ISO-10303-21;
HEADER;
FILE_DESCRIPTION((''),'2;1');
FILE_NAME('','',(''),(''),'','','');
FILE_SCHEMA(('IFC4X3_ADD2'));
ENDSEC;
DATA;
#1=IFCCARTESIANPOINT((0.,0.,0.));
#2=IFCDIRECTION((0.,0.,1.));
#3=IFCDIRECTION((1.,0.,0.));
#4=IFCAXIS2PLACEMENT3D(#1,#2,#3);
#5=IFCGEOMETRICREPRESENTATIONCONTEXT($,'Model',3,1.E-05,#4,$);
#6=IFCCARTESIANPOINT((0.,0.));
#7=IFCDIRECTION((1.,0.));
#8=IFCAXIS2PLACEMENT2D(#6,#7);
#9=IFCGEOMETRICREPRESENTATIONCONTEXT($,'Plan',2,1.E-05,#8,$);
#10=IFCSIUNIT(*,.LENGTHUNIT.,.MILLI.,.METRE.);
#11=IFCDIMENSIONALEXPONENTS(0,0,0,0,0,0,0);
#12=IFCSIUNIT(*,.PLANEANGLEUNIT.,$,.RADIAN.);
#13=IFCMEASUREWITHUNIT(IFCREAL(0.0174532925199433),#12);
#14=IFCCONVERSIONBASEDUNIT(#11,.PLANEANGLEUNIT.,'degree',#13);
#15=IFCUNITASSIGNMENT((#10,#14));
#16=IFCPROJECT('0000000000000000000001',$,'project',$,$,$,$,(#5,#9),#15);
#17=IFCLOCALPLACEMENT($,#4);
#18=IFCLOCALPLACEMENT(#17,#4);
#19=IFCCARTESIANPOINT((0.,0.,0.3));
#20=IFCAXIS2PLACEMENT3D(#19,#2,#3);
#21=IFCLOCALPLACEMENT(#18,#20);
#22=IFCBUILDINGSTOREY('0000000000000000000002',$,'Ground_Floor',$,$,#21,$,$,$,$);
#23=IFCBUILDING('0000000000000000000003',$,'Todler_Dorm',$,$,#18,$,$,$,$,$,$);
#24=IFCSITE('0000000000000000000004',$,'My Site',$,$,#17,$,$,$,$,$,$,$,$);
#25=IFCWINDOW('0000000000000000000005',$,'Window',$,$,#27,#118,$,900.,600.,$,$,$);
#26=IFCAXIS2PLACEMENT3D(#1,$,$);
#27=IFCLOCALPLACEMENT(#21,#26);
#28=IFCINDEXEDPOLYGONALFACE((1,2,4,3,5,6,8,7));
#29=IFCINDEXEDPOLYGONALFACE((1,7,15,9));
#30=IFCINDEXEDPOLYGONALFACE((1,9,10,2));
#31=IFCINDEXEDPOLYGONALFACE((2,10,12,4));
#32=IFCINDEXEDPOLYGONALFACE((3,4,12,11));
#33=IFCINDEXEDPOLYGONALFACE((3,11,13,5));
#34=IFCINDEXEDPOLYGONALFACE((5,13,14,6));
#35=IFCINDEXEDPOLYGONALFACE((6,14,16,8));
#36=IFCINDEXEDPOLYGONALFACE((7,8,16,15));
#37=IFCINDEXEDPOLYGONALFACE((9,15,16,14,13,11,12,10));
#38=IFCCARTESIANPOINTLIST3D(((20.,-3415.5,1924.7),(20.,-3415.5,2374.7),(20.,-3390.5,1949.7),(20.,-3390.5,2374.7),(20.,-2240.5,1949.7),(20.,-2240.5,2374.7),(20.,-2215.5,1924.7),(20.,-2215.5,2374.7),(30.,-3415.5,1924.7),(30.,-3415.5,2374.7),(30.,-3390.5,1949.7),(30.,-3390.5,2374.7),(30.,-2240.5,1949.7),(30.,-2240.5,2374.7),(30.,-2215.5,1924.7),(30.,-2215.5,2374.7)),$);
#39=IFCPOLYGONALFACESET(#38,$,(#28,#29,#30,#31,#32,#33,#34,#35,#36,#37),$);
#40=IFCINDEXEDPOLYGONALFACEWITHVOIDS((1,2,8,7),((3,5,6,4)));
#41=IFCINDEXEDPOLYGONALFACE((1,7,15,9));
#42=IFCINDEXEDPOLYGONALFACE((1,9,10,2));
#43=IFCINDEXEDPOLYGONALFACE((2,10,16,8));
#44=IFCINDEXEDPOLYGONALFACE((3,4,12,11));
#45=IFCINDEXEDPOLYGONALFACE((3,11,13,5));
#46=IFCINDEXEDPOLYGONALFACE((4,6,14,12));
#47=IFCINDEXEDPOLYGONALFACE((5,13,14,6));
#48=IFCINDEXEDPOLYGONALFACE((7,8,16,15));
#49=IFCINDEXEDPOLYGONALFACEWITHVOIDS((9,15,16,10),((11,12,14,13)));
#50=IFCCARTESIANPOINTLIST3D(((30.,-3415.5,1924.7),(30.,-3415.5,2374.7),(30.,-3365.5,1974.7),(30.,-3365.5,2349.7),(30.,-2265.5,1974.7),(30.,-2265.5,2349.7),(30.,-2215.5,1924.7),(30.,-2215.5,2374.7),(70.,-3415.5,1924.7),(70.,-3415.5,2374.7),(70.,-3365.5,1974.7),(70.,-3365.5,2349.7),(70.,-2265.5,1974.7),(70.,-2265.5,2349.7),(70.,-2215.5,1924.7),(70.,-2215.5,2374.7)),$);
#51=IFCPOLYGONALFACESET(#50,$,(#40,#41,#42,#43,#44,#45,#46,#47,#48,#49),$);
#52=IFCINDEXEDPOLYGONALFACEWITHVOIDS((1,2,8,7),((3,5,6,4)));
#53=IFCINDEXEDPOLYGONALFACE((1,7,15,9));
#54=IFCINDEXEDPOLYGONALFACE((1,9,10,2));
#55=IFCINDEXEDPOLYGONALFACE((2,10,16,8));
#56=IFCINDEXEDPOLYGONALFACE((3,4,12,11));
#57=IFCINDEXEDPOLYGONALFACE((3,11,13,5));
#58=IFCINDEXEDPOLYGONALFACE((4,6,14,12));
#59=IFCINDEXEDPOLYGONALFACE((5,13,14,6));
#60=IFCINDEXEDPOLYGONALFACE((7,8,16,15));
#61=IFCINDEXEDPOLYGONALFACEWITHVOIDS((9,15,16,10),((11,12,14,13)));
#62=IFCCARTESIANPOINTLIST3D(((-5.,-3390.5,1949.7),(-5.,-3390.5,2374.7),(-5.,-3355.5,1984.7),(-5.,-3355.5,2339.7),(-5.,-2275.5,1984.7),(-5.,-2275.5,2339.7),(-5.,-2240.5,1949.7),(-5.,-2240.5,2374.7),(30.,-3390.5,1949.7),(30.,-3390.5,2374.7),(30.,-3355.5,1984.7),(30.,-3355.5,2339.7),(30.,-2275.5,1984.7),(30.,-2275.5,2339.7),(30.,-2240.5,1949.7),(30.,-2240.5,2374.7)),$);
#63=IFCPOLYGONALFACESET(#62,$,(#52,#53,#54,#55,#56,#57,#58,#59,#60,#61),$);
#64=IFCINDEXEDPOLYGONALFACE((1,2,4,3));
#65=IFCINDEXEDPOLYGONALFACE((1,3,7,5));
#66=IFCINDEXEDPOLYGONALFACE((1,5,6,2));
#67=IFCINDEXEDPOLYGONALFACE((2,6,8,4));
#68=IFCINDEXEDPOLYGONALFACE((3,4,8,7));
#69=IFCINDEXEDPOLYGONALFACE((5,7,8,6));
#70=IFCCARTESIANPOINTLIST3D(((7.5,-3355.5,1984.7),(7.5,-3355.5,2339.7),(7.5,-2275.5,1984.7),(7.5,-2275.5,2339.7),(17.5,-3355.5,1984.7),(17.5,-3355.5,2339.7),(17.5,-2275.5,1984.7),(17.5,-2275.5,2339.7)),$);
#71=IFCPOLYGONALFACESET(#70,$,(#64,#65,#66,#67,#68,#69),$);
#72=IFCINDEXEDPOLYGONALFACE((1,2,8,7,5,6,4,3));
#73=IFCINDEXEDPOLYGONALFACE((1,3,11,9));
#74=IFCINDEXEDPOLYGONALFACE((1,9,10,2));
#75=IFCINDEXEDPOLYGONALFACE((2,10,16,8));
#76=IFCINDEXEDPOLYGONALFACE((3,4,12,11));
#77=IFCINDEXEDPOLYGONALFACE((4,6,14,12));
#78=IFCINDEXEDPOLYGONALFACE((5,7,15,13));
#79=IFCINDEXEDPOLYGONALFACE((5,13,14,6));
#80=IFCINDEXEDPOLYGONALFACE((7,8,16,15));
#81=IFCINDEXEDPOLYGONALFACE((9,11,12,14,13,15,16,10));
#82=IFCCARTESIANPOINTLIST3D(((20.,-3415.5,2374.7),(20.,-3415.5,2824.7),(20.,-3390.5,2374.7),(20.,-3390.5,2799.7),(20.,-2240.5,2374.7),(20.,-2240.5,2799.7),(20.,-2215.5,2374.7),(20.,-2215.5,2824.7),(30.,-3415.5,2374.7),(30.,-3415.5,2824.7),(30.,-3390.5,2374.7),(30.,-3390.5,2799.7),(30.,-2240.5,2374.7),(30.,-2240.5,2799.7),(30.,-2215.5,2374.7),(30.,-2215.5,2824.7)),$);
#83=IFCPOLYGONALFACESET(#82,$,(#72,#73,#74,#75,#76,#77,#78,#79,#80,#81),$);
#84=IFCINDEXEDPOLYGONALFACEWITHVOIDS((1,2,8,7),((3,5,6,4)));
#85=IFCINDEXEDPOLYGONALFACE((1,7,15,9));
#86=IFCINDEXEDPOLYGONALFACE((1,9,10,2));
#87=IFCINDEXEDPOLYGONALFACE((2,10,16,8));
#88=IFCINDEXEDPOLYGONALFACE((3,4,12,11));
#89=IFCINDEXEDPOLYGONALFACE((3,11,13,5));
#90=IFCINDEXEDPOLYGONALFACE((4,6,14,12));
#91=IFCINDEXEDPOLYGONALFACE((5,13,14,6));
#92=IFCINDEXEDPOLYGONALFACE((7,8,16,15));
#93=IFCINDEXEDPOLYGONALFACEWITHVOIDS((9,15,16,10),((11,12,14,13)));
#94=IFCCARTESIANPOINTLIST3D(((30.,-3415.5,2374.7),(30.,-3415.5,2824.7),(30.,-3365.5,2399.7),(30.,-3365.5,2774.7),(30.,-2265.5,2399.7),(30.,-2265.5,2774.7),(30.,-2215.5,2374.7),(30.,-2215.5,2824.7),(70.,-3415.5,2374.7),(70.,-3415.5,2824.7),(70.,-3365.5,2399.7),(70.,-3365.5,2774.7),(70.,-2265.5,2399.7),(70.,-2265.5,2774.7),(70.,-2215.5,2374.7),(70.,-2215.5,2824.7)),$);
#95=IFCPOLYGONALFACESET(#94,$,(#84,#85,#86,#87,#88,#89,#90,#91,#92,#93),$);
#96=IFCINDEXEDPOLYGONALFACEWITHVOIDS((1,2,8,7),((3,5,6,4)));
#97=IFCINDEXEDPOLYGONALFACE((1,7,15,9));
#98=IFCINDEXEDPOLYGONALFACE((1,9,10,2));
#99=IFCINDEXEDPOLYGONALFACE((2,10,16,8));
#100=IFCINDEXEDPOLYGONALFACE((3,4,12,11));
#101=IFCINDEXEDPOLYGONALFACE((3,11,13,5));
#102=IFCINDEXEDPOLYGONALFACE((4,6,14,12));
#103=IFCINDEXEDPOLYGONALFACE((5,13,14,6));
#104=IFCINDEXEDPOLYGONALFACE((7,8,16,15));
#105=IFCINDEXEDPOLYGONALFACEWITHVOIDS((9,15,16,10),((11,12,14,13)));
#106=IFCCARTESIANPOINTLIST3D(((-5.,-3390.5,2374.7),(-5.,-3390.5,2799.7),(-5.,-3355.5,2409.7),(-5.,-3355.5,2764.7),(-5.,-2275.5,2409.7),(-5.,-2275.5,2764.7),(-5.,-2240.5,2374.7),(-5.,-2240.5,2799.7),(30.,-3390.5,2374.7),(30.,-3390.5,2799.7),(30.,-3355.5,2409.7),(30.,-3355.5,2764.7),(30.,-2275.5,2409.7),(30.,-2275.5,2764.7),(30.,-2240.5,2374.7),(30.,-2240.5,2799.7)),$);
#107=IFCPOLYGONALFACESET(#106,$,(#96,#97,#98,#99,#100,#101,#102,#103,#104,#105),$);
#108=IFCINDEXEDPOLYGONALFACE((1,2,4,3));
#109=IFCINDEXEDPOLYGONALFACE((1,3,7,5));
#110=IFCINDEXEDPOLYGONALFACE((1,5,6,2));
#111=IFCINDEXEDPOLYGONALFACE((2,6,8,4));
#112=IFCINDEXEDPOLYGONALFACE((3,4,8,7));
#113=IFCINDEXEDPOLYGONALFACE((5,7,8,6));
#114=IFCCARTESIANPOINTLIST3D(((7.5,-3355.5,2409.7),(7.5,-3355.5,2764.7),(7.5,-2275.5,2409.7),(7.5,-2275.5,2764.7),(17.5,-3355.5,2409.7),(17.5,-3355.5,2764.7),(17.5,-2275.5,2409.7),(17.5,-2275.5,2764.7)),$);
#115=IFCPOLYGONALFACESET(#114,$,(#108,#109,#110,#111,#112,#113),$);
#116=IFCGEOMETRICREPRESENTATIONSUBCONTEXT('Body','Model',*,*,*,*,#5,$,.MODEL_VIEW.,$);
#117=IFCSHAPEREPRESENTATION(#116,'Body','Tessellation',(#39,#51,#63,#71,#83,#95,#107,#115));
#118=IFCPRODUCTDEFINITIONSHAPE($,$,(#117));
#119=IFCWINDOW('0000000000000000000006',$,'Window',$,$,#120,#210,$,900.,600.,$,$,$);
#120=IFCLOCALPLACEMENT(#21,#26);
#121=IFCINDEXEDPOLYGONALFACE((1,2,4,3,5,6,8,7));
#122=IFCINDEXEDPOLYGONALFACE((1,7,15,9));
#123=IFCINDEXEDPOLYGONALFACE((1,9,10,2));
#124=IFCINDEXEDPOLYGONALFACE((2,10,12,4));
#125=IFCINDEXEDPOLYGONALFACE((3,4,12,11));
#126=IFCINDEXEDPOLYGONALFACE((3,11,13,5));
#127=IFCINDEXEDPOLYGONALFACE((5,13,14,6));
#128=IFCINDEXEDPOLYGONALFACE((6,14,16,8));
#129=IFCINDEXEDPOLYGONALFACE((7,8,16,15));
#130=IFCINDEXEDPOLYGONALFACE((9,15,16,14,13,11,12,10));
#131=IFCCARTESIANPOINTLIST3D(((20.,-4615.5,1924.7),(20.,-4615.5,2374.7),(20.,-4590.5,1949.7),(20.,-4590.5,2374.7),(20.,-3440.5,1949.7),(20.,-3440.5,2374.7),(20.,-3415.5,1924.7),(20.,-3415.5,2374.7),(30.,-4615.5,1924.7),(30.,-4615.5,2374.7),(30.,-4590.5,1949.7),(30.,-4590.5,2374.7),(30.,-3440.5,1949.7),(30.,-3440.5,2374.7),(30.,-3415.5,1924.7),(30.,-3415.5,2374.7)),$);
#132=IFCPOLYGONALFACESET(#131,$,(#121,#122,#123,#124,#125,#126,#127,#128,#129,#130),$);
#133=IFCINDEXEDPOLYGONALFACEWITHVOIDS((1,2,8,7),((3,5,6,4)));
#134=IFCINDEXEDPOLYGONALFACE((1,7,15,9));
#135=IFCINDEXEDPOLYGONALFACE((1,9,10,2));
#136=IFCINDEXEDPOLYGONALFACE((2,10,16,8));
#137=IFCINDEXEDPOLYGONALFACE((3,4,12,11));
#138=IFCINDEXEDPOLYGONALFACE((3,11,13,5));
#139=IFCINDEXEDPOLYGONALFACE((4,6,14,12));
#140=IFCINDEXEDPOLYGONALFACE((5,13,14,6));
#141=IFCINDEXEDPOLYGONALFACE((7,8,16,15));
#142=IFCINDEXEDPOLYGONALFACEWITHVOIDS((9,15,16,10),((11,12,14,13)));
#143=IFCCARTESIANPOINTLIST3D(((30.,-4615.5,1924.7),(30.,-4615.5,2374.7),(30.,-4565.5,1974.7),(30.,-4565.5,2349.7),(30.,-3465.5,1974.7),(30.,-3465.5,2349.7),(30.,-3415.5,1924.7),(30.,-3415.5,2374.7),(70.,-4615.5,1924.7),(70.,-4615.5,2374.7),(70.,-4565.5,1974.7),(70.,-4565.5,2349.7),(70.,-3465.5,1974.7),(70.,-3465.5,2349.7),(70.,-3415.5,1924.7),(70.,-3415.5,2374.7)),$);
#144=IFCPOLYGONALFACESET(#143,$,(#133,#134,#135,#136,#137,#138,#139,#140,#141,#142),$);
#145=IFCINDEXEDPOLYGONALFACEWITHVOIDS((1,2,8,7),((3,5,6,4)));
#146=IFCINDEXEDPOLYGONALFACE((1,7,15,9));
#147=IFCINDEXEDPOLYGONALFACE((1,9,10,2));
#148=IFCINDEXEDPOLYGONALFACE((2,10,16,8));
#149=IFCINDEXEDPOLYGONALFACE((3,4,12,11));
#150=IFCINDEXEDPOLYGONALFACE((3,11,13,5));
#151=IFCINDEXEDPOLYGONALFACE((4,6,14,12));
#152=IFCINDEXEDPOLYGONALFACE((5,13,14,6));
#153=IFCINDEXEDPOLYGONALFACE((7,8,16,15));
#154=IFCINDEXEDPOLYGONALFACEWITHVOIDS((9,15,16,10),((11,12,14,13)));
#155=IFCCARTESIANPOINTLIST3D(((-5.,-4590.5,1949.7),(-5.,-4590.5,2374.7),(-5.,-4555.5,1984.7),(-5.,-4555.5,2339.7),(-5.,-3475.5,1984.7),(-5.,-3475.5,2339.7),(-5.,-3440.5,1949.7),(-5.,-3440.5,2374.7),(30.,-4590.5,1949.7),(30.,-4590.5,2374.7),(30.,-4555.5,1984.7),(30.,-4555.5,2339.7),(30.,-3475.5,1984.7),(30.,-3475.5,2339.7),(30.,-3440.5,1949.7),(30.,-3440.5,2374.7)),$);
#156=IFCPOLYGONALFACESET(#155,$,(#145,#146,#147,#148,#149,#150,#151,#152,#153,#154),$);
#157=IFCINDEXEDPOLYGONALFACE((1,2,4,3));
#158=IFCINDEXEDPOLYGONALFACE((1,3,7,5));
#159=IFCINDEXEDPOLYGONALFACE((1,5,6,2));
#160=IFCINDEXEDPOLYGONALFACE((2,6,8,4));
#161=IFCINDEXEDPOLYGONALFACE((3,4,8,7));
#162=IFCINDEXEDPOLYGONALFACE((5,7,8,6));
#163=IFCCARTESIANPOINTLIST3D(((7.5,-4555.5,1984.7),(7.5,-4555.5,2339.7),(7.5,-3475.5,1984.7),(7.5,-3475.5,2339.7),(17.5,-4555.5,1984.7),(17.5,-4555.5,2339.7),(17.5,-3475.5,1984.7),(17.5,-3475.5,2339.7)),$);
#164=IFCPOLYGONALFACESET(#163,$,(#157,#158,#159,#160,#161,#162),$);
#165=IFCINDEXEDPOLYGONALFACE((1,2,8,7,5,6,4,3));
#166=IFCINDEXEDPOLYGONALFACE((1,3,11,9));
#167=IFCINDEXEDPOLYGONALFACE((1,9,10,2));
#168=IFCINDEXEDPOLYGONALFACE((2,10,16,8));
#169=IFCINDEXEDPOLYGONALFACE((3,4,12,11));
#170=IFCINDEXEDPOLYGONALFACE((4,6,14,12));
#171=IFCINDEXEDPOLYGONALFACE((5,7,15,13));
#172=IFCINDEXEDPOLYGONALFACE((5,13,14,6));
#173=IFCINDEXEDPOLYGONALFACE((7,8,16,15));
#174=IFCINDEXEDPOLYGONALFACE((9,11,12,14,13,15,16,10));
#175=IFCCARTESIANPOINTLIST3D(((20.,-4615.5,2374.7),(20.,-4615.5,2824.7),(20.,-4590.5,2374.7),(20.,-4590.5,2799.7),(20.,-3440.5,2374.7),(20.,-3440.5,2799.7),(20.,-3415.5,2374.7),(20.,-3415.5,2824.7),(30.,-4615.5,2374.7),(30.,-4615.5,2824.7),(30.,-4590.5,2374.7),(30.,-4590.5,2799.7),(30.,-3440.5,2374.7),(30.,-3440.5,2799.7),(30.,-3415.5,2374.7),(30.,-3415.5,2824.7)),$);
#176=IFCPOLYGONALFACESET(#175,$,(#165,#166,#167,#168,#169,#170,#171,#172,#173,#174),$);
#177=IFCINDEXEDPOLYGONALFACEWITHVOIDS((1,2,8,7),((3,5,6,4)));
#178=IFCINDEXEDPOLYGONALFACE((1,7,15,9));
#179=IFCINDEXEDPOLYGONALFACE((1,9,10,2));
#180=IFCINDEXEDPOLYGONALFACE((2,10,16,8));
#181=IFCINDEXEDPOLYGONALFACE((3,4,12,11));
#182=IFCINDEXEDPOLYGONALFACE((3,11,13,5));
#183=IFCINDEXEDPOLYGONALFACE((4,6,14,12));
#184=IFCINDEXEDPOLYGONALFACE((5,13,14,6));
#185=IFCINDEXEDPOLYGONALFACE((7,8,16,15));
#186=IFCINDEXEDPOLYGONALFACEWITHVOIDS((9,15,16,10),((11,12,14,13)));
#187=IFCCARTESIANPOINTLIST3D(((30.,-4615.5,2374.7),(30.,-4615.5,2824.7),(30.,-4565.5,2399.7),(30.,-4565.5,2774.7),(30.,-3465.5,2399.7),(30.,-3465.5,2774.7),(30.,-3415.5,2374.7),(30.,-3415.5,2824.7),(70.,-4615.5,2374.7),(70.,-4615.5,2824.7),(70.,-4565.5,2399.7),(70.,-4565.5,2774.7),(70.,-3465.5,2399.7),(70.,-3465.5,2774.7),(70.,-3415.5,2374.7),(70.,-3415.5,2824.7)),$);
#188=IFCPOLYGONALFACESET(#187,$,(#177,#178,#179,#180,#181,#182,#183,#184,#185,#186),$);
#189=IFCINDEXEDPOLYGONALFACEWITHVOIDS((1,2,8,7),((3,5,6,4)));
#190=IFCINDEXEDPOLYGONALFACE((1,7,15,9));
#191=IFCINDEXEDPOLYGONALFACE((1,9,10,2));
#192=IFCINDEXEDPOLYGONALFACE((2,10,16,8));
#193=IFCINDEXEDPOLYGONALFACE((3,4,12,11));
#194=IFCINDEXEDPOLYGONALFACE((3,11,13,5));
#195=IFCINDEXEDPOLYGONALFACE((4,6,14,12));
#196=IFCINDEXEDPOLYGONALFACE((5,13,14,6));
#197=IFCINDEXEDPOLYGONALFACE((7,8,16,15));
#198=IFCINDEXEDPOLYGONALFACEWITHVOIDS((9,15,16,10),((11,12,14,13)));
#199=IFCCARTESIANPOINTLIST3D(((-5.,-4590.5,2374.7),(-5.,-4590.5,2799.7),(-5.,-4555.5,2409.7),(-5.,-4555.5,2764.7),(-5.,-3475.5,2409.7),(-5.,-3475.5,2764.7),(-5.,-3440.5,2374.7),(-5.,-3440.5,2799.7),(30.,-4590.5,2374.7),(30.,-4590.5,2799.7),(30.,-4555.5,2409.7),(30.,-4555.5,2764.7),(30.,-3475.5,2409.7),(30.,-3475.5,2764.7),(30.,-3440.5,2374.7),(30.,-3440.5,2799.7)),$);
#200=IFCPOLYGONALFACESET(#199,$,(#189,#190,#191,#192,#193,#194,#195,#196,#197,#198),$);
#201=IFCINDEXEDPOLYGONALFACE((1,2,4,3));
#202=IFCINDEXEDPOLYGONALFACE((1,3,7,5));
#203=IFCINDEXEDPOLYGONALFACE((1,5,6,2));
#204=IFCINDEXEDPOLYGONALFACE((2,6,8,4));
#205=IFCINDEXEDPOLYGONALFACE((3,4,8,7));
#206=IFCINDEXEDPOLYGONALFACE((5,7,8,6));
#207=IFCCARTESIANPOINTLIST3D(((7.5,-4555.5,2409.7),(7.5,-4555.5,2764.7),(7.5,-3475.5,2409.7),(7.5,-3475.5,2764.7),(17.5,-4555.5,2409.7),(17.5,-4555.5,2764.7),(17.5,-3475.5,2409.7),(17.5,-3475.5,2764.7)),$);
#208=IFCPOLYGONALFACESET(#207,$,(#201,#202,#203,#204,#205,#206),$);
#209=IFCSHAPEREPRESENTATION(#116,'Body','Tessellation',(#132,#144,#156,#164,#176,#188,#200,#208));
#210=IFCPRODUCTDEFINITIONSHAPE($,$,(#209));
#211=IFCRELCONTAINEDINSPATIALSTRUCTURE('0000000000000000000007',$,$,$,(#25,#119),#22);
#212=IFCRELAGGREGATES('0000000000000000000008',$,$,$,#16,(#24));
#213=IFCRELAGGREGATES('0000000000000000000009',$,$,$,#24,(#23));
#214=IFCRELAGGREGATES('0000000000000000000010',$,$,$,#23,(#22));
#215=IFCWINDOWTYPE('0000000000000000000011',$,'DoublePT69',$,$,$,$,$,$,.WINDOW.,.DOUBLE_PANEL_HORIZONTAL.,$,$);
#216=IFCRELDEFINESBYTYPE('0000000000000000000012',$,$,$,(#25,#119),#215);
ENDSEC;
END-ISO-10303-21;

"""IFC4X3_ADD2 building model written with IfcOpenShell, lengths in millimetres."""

from ifc_helpers import new_model, entity, si_unit, converted_unit, frame, origin_with_axes, origin_2d_with_axis, place, context, subcontext, project, spatial, line, indexed_curve, outline, extrude, shape, source, transform, mapped, type_object, type_shapes, element, save


model = new_model("IFC4X3_ADD2")

# Units and contexts
model_context = context("Model", 3, precision=1e-05, world=origin_with_axes())
plan_context = context("Plan", 2, precision=1e-05, world=origin_2d_with_axis())
body_context_1 = subcontext(model_context, "Body", "Model", "MODEL_VIEW")
body_context_2 = subcontext(plan_context, "Body", "Plan", "PLAN_VIEW")
ifc_project = project(units=[si_unit("LENGTHUNIT", "METRE", prefix="MILLI"), converted_unit("PLANEANGLEUNIT", "degree", entity("IfcReal", 0.0174532925199433), si_unit("PLANEANGLEUNIT", "RADIAN"), dimensions=[0, 0, 0, 0, 0, 0, 0])], contexts=[model_context, plan_context])

# Site, building, storey
site_placement = place(None, origin_with_axes())
site = spatial("IfcSite", under=ifc_project, at=site_placement, Name="My Site")
building_placement = place(site_placement, origin_with_axes())
building = spatial("IfcBuilding", under=site, at=building_placement, Name="Todler_Dorm")
storey_placement = place(building_placement, frame((0.0, 0.0, 0.3), z_axis=(0.0, 0.0, 1.0), x_axis=(1.0, 0.0, 0.0)))
storey = spatial("IfcBuildingStorey", under=building, at=storey_placement, Name="Ground_Floor")

# Windows
window_type_1 = type_object("IfcWindowType", Name="DoublePT69", PartitioningType="DOUBLE_PANEL_HORIZONTAL", PredefinedType="WINDOW")
shared_shape_1 = source(origin_with_axes(), body_context_1, "Body", "SweptSolid", [
    extrude(outline(indexed_curve([(1200.0, 450.0), (1200.0, 0.0), (0.0, 0.0), (0.0, 450.0), (25.0, 450.0), (25.0, 25.0), (1175.0, 25.0), (1175.0, 450.0)], segments=[line(1, 2, 3, 4, 5, 6, 7, 8, 1)])), frame((0.0, 90.0, 0.0), z_axis=(0.0, -1.0, 0.0), x_axis=(1.0, 0.0, 0.0)), (0.0, 0.0, -1.0), 10.0),
    extrude(outline(indexed_curve([(0.0, 0.0), (1200.0, 0.0), (1200.0, 450.0), (0.0, 450.0)], segments=[line(1, 2, 3, 4, 1)]), holes=[indexed_curve([(50.0, 50.0), (1150.0, 50.0), (1150.0, 425.0), (50.0, 425.0)], segments=[line(1, 2, 3, 4, 1)])]), frame((0.0, 50.0, 0.0), z_axis=(0.0, -1.0, 0.0), x_axis=(1.0, 0.0, 0.0)), (0.0, 0.0, -1.0), 40.0),
    extrude(outline(indexed_curve([(0.0, 0.0), (1150.0, 0.0), (1150.0, 425.0), (0.0, 425.0)], segments=[line(1, 2, 3, 4, 1)]), holes=[indexed_curve([(35.0, 35.0), (1115.0, 35.0), (1115.0, 390.0), (35.0, 390.0)], segments=[line(1, 2, 3, 4, 1)])]), frame((25.0, 90.0, 25.0), z_axis=(0.0, -1.0, 0.0), x_axis=(1.0, 0.0, 0.0)), (0.0, 0.0, -1.0), 35.0),
    extrude(outline(indexed_curve([(35.0, 35.0), (1115.0, 35.0), (1115.0, 390.0), (35.0, 390.0)], segments=[line(1, 2, 3, 4, 1)])), frame((25.0, 102.5, 25.0), z_axis=(0.0, -1.0, 0.0), x_axis=(1.0, 0.0, 0.0)), (0.0, 0.0, -1.0), 10.0),
    extrude(outline(indexed_curve([(0.0, 0.0), (0.0, 450.0), (1200.0, 450.0), (1200.0, 0.0), (1175.0, 0.0), (1175.0, 425.0), (25.0, 425.0), (25.0, 0.0)], segments=[line(1, 2, 3, 4, 5, 6, 7, 8, 1)])), frame((0.0, 90.0, 450.0), z_axis=(0.0, -1.0, 0.0), x_axis=(1.0, 0.0, 0.0)), (0.0, 0.0, -1.0), 10.0),
    extrude(outline(indexed_curve([(0.0, 0.0), (1200.0, 0.0), (1200.0, 450.0), (0.0, 450.0)], segments=[line(1, 2, 3, 4, 1)]), holes=[indexed_curve([(50.0, 25.0), (1150.0, 25.0), (1150.0, 400.0), (50.0, 400.0)], segments=[line(1, 2, 3, 4, 1)])]), frame((0.0, 50.0, 450.0), z_axis=(0.0, -1.0, 0.0), x_axis=(1.0, 0.0, 0.0)), (0.0, 0.0, -1.0), 40.0),
    extrude(outline(indexed_curve([(0.0, 0.0), (1150.0, 0.0), (1150.0, 425.0), (0.0, 425.0)], segments=[line(1, 2, 3, 4, 1)]), holes=[indexed_curve([(35.0, 35.0), (1115.0, 35.0), (1115.0, 390.0), (35.0, 390.0)], segments=[line(1, 2, 3, 4, 1)])]), frame((25.0, 90.0, 450.0), z_axis=(0.0, -1.0, 0.0), x_axis=(1.0, 0.0, 0.0)), (0.0, 0.0, -1.0), 35.0),
    extrude(outline(indexed_curve([(35.0, 35.0), (1115.0, 35.0), (1115.0, 390.0), (35.0, 390.0)], segments=[line(1, 2, 3, 4, 1)])), frame((25.0, 102.5, 450.0), z_axis=(0.0, -1.0, 0.0), x_axis=(1.0, 0.0, 0.0)), (0.0, 0.0, -1.0), 10.0),
])
shared_shape_2 = source(origin_with_axes(), body_context_2, "Body", "Curve2D", [
    entity("IfcIndexedPolyCurve", entity("IfcCartesianPointList2D", [[50.0, 50.0], [1150.0, 50.0]])),
    entity("IfcIndexedPolyCurve", entity("IfcCartesianPointList2D", [[0.0, 100.0], [25.0, 100.0], [25.0, 90.0], [50.0, 90.0], [50.0, 50.0], [0.0, 50.0]]), [entity("IfcLineIndex", [1, 2, 3, 4, 5, 6, 1])]),
    entity("IfcIndexedPolyCurve", entity("IfcCartesianPointList2D", [[1200.0, 100.0], [1175.0, 100.0], [1175.0, 90.0], [1150.0, 90.0], [1150.0, 50.0], [1200.0, 50.0]]), [entity("IfcLineIndex", [1, 2, 3, 4, 5, 6, 1])]),
    entity("IfcIndexedPolyCurve", entity("IfcCartesianPointList2D", [[25.0, 90.0], [60.0, 90.0], [60.0, 125.0], [25.0, 125.0]]), [entity("IfcLineIndex", [1, 2, 3, 4, 1])]),
    entity("IfcIndexedPolyCurve", entity("IfcCartesianPointList2D", [[1175.0, 90.0], [1140.0, 90.0], [1140.0, 125.0], [1175.0, 125.0]]), [entity("IfcLineIndex", [1, 2, 3, 4, 1])]),
    entity("IfcIndexedPolyCurve", entity("IfcCartesianPointList2D", [[60.0, 90.0], [1140.0, 90.0]])),
    entity("IfcIndexedPolyCurve", entity("IfcCartesianPointList2D", [[60.0, 125.0], [1140.0, 125.0]])),
    entity("IfcIndexedPolyCurve", entity("IfcCartesianPointList2D", [[60.0, 107.5], [1140.0, 107.5]])),
])
type_shapes(window_type_1, [shared_shape_1, shared_shape_2])
for number, where, z_axis, x_axis, name in (
    (1, (120.0, -3415.5, 1924.7), (0.0, 0.0, 1.0), (0.0, 1.0, 0.0), "Window"),
    (2, (120.0, -4615.5, 1924.7), (0.0, 0.0, 1.0), (0.0, 1.0, 0.0), "Window"),
):
    element("IfcWindow", number, at=place(storey_placement, frame(where, z_axis=z_axis, x_axis=x_axis)), inside=storey, type_object=window_type_1, Name=name, OverallHeight=900.0, OverallWidth=600.0, shapes=[
        shape(body_context_1, "Body", "MappedRepresentation", [mapped(shared_shape_1, transform((0.0, 0.0, 0.0), x_axis=(1.0, 0.0, 0.0), y_axis=(0.0, 1.0, 0.0), z_axis=(0.0, 0.0, 1.0), scale=1.0))]),
        shape(body_context_2, "Body", "MappedRepresentation", [mapped(shared_shape_2, transform((0.0, 0.0, 0.0), x_axis=(1.0, 0.0, 0.0), y_axis=(0.0, 1.0, 0.0), z_axis=(0.0, 0.0, 1.0), scale=1.0))]),
    ])

save(model, "model.ifc")
